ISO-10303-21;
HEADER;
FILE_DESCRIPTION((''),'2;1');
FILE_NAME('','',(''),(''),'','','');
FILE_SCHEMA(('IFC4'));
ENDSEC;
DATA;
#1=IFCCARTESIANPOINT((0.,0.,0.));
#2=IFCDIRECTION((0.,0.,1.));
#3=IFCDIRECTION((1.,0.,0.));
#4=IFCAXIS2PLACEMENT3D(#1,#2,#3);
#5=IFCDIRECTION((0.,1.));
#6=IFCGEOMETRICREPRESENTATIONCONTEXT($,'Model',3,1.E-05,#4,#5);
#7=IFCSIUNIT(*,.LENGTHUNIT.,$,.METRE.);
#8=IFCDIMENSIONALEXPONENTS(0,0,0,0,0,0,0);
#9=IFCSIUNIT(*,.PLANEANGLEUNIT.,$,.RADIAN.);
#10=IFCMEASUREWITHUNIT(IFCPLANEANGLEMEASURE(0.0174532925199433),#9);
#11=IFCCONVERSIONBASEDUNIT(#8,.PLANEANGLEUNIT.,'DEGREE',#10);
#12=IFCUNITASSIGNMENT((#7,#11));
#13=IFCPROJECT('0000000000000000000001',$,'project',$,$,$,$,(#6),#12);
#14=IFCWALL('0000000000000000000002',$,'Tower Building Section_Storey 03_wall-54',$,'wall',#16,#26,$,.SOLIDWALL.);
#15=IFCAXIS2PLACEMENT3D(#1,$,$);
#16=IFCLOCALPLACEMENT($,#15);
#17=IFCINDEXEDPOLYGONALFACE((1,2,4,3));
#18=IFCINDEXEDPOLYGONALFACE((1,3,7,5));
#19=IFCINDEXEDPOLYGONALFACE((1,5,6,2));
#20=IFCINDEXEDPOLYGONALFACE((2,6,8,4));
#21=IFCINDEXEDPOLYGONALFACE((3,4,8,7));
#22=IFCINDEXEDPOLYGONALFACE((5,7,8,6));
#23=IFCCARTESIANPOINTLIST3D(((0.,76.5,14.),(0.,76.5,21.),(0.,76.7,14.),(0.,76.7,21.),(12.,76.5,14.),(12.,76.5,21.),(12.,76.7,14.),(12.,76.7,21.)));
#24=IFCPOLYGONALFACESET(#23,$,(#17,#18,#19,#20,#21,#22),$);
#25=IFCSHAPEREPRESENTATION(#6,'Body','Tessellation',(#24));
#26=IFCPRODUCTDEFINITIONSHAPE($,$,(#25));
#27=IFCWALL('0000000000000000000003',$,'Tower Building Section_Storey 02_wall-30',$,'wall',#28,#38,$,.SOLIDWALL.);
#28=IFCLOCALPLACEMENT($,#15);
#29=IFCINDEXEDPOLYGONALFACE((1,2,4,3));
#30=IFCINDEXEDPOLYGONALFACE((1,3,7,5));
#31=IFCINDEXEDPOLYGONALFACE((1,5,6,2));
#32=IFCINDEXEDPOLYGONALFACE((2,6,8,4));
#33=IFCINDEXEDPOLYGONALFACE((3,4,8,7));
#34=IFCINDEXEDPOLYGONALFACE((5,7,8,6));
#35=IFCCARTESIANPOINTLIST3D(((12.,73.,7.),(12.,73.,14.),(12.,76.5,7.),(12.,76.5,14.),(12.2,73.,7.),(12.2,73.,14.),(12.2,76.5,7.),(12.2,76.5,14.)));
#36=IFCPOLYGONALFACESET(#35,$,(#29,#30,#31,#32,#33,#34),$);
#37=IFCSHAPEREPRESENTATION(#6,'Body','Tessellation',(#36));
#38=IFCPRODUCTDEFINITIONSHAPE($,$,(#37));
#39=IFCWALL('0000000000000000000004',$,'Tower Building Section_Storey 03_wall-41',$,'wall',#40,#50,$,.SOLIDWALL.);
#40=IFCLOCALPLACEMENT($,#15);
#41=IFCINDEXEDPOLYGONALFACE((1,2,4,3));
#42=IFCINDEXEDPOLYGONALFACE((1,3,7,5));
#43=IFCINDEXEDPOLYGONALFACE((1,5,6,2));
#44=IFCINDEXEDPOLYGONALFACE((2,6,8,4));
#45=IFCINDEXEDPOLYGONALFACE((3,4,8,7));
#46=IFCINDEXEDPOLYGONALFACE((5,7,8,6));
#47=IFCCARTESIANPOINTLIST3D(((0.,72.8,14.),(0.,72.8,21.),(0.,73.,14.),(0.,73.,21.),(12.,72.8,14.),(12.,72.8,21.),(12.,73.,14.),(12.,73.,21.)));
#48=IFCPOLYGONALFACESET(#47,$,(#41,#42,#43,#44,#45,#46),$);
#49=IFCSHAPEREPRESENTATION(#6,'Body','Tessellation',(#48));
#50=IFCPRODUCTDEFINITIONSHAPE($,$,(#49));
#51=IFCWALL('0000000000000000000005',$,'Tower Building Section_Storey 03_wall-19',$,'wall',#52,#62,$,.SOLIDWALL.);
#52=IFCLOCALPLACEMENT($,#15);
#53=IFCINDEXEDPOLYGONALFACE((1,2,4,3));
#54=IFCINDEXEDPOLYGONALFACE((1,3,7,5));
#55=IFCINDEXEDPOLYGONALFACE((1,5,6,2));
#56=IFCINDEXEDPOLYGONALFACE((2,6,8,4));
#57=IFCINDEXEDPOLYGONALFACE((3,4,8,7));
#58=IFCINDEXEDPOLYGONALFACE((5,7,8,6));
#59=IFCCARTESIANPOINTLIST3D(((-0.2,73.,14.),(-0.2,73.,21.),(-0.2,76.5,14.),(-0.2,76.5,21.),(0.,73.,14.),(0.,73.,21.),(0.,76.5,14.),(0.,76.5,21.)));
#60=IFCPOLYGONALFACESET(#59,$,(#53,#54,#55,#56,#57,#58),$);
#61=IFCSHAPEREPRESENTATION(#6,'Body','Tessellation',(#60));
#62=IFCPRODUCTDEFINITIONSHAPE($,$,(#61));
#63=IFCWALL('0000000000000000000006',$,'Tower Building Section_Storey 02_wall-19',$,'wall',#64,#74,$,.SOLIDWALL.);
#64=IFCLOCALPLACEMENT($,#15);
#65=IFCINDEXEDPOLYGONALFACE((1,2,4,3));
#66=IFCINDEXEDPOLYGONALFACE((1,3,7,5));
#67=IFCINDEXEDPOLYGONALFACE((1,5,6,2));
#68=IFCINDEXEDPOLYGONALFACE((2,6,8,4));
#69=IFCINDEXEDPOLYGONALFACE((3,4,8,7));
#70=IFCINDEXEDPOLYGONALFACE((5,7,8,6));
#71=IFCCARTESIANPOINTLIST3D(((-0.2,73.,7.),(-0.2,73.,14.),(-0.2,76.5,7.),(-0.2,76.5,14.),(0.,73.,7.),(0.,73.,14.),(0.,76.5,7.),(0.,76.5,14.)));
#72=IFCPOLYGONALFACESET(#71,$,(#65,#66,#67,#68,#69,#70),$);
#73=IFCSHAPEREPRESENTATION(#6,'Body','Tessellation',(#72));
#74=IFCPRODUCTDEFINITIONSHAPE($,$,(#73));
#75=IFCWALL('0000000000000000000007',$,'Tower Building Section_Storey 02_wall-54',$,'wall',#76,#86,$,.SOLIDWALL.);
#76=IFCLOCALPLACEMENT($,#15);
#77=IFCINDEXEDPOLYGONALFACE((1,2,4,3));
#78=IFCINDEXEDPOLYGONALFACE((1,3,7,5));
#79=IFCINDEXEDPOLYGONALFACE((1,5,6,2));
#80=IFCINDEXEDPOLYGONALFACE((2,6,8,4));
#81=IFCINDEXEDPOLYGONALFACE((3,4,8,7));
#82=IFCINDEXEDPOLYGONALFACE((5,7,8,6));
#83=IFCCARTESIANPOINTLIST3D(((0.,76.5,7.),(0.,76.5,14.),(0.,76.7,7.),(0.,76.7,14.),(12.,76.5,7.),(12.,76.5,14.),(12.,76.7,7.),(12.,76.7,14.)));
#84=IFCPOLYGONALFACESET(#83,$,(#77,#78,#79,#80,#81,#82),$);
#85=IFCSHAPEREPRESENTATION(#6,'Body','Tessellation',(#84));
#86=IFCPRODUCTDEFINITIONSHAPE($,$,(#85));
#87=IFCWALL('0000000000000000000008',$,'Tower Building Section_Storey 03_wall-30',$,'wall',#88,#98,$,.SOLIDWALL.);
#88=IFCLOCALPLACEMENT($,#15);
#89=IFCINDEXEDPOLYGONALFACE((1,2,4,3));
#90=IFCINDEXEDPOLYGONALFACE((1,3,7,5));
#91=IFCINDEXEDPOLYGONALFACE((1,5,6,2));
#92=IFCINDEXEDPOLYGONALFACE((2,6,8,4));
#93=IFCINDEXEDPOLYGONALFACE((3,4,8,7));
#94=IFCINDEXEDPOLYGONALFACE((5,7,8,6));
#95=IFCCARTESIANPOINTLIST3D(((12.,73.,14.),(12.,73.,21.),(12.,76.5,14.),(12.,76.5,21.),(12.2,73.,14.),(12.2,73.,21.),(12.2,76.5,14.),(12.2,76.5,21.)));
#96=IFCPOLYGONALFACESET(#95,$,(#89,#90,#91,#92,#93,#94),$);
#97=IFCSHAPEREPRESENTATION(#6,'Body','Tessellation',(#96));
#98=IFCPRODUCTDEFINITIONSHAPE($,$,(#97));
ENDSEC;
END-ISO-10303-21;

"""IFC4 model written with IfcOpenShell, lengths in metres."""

from ifc_helpers import new_model, entity, si_unit, converted_unit, direction, frame, origin_with_axes, place, context, project, polyline, outline, extrude, element, save


model = new_model("IFC4")

# Units and contexts
model_context = context("Model", 3, precision=1e-05, world=origin_with_axes(), true_north=direction((0.0, 1.0)))
ifc_project = project(units=[si_unit("LENGTHUNIT", "METRE"), converted_unit("PLANEANGLEUNIT", "DEGREE", entity("IfcPlaneAngleMeasure", 0.0174532925199433), si_unit("PLANEANGLEUNIT", "RADIAN"), dimensions=[0, 0, 0, 0, 0, 0, 0])], contexts=[model_context])

# Shared definitions
placement_1 = place(None, origin_with_axes())
placement_2 = place(placement_1, frame((0.0, 0.0, 14.0), z_axis=(0.0, 0.0, 1.0), x_axis=(1.0, 0.0, 0.0)))

# Walls
placement_3 = place(placement_1, frame((0.0, 0.0, 7.0), z_axis=(0.0, 0.0, 1.0), x_axis=(1.0, 0.0, 0.0)))
wall_1_placement = place(placement_2, frame((6.0, 76.5, 3.5), z_axis=(0.0, 1.0, 0.0), x_axis=(0.0, 0.0, 1.0)))
element("IfcWall", 1, at=wall_1_placement, Name="Tower Building Section_Storey 03_wall-54", ObjectType="wall", PredefinedType="SOLIDWALL", context=model_context, body=[
    extrude(outline(polyline([(-3.5, -6.0, 0.0), (3.5, -6.0, 0.0), (3.5, 6.0, 0.0), (-3.5, 6.0, 0.0), (-3.5, -6.0, 0.0)])), origin_with_axes(), (0.0, 0.0, 1.0), 0.2),
])
wall_2_placement = place(placement_3, frame((12.2, 74.75, 3.5), z_axis=(-1.0, 0.0, 0.0), x_axis=(0.0, 0.0, 1.0)))
element("IfcWall", 2, at=wall_2_placement, Name="Tower Building Section_Storey 02_wall-30", ObjectType="wall", PredefinedType="SOLIDWALL", context=model_context, body=[
    extrude(outline(polyline([(-3.5, -1.75, 0.0), (3.5, -1.75, 0.0), (3.5, 1.75, 0.0), (-3.5, 1.75, 0.0), (-3.5, -1.75, 0.0)])), origin_with_axes(), (0.0, 0.0, 1.0), 0.2),
])
wall_3_placement = place(placement_2, frame((6.0, 72.8, 3.5), z_axis=(0.0, 1.0, 0.0), x_axis=(0.0, 0.0, 1.0)))
element("IfcWall", 3, at=wall_3_placement, Name="Tower Building Section_Storey 03_wall-41", ObjectType="wall", PredefinedType="SOLIDWALL", context=model_context, body=[
    extrude(outline(polyline([(-3.5, -6.0, 0.0), (3.5, -6.0, 0.0), (3.5, 6.0, 0.0), (-3.5, 6.0, 0.0), (-3.5, -6.0, 0.0)])), origin_with_axes(), (0.0, 0.0, 1.0), 0.2),
])
wall_4_placement = place(placement_2, frame((0.0, 74.75, 3.5), z_axis=(-1.0, 0.0, 0.0), x_axis=(0.0, 0.0, 1.0)))
element("IfcWall", 4, at=wall_4_placement, Name="Tower Building Section_Storey 03_wall-19", ObjectType="wall", PredefinedType="SOLIDWALL", context=model_context, body=[
    extrude(outline(polyline([(-3.5, -1.75, 0.0), (3.5, -1.75, 0.0), (3.5, 1.75, 0.0), (-3.5, 1.75, 0.0), (-3.5, -1.75, 0.0)])), origin_with_axes(), (0.0, 0.0, 1.0), 0.2),
])
wall_5_placement = place(placement_3, frame((0.0, 74.75, 3.5), z_axis=(-1.0, 0.0, 0.0), x_axis=(0.0, 0.0, 1.0)))
element("IfcWall", 5, at=wall_5_placement, Name="Tower Building Section_Storey 02_wall-19", ObjectType="wall", PredefinedType="SOLIDWALL", context=model_context, body=[
    extrude(outline(polyline([(-3.5, -1.75, 0.0), (3.5, -1.75, 0.0), (3.5, 1.75, 0.0), (-3.5, 1.75, 0.0), (-3.5, -1.75, 0.0)])), origin_with_axes(), (0.0, 0.0, 1.0), 0.2),
])
wall_6_placement = place(placement_3, frame((6.0, 76.5, 3.5), z_axis=(0.0, 1.0, 0.0), x_axis=(0.0, 0.0, 1.0)))
element("IfcWall", 6, at=wall_6_placement, Name="Tower Building Section_Storey 02_wall-54", ObjectType="wall", PredefinedType="SOLIDWALL", context=model_context, body=[
    extrude(outline(polyline([(-3.5, -6.0, 0.0), (3.5, -6.0, 0.0), (3.5, 6.0, 0.0), (-3.5, 6.0, 0.0), (-3.5, -6.0, 0.0)])), origin_with_axes(), (0.0, 0.0, 1.0), 0.2),
])
wall_7_placement = place(placement_2, frame((12.2, 74.75, 3.5), z_axis=(-1.0, 0.0, 0.0), x_axis=(0.0, 0.0, 1.0)))
element("IfcWall", 7, at=wall_7_placement, Name="Tower Building Section_Storey 03_wall-30", ObjectType="wall", PredefinedType="SOLIDWALL", context=model_context, body=[
    extrude(outline(polyline([(-3.5, -1.75, 0.0), (3.5, -1.75, 0.0), (3.5, 1.75, 0.0), (-3.5, 1.75, 0.0), (-3.5, -1.75, 0.0)])), origin_with_axes(), (0.0, 0.0, 1.0), 0.2),
])

save(model, "model.ifc")
